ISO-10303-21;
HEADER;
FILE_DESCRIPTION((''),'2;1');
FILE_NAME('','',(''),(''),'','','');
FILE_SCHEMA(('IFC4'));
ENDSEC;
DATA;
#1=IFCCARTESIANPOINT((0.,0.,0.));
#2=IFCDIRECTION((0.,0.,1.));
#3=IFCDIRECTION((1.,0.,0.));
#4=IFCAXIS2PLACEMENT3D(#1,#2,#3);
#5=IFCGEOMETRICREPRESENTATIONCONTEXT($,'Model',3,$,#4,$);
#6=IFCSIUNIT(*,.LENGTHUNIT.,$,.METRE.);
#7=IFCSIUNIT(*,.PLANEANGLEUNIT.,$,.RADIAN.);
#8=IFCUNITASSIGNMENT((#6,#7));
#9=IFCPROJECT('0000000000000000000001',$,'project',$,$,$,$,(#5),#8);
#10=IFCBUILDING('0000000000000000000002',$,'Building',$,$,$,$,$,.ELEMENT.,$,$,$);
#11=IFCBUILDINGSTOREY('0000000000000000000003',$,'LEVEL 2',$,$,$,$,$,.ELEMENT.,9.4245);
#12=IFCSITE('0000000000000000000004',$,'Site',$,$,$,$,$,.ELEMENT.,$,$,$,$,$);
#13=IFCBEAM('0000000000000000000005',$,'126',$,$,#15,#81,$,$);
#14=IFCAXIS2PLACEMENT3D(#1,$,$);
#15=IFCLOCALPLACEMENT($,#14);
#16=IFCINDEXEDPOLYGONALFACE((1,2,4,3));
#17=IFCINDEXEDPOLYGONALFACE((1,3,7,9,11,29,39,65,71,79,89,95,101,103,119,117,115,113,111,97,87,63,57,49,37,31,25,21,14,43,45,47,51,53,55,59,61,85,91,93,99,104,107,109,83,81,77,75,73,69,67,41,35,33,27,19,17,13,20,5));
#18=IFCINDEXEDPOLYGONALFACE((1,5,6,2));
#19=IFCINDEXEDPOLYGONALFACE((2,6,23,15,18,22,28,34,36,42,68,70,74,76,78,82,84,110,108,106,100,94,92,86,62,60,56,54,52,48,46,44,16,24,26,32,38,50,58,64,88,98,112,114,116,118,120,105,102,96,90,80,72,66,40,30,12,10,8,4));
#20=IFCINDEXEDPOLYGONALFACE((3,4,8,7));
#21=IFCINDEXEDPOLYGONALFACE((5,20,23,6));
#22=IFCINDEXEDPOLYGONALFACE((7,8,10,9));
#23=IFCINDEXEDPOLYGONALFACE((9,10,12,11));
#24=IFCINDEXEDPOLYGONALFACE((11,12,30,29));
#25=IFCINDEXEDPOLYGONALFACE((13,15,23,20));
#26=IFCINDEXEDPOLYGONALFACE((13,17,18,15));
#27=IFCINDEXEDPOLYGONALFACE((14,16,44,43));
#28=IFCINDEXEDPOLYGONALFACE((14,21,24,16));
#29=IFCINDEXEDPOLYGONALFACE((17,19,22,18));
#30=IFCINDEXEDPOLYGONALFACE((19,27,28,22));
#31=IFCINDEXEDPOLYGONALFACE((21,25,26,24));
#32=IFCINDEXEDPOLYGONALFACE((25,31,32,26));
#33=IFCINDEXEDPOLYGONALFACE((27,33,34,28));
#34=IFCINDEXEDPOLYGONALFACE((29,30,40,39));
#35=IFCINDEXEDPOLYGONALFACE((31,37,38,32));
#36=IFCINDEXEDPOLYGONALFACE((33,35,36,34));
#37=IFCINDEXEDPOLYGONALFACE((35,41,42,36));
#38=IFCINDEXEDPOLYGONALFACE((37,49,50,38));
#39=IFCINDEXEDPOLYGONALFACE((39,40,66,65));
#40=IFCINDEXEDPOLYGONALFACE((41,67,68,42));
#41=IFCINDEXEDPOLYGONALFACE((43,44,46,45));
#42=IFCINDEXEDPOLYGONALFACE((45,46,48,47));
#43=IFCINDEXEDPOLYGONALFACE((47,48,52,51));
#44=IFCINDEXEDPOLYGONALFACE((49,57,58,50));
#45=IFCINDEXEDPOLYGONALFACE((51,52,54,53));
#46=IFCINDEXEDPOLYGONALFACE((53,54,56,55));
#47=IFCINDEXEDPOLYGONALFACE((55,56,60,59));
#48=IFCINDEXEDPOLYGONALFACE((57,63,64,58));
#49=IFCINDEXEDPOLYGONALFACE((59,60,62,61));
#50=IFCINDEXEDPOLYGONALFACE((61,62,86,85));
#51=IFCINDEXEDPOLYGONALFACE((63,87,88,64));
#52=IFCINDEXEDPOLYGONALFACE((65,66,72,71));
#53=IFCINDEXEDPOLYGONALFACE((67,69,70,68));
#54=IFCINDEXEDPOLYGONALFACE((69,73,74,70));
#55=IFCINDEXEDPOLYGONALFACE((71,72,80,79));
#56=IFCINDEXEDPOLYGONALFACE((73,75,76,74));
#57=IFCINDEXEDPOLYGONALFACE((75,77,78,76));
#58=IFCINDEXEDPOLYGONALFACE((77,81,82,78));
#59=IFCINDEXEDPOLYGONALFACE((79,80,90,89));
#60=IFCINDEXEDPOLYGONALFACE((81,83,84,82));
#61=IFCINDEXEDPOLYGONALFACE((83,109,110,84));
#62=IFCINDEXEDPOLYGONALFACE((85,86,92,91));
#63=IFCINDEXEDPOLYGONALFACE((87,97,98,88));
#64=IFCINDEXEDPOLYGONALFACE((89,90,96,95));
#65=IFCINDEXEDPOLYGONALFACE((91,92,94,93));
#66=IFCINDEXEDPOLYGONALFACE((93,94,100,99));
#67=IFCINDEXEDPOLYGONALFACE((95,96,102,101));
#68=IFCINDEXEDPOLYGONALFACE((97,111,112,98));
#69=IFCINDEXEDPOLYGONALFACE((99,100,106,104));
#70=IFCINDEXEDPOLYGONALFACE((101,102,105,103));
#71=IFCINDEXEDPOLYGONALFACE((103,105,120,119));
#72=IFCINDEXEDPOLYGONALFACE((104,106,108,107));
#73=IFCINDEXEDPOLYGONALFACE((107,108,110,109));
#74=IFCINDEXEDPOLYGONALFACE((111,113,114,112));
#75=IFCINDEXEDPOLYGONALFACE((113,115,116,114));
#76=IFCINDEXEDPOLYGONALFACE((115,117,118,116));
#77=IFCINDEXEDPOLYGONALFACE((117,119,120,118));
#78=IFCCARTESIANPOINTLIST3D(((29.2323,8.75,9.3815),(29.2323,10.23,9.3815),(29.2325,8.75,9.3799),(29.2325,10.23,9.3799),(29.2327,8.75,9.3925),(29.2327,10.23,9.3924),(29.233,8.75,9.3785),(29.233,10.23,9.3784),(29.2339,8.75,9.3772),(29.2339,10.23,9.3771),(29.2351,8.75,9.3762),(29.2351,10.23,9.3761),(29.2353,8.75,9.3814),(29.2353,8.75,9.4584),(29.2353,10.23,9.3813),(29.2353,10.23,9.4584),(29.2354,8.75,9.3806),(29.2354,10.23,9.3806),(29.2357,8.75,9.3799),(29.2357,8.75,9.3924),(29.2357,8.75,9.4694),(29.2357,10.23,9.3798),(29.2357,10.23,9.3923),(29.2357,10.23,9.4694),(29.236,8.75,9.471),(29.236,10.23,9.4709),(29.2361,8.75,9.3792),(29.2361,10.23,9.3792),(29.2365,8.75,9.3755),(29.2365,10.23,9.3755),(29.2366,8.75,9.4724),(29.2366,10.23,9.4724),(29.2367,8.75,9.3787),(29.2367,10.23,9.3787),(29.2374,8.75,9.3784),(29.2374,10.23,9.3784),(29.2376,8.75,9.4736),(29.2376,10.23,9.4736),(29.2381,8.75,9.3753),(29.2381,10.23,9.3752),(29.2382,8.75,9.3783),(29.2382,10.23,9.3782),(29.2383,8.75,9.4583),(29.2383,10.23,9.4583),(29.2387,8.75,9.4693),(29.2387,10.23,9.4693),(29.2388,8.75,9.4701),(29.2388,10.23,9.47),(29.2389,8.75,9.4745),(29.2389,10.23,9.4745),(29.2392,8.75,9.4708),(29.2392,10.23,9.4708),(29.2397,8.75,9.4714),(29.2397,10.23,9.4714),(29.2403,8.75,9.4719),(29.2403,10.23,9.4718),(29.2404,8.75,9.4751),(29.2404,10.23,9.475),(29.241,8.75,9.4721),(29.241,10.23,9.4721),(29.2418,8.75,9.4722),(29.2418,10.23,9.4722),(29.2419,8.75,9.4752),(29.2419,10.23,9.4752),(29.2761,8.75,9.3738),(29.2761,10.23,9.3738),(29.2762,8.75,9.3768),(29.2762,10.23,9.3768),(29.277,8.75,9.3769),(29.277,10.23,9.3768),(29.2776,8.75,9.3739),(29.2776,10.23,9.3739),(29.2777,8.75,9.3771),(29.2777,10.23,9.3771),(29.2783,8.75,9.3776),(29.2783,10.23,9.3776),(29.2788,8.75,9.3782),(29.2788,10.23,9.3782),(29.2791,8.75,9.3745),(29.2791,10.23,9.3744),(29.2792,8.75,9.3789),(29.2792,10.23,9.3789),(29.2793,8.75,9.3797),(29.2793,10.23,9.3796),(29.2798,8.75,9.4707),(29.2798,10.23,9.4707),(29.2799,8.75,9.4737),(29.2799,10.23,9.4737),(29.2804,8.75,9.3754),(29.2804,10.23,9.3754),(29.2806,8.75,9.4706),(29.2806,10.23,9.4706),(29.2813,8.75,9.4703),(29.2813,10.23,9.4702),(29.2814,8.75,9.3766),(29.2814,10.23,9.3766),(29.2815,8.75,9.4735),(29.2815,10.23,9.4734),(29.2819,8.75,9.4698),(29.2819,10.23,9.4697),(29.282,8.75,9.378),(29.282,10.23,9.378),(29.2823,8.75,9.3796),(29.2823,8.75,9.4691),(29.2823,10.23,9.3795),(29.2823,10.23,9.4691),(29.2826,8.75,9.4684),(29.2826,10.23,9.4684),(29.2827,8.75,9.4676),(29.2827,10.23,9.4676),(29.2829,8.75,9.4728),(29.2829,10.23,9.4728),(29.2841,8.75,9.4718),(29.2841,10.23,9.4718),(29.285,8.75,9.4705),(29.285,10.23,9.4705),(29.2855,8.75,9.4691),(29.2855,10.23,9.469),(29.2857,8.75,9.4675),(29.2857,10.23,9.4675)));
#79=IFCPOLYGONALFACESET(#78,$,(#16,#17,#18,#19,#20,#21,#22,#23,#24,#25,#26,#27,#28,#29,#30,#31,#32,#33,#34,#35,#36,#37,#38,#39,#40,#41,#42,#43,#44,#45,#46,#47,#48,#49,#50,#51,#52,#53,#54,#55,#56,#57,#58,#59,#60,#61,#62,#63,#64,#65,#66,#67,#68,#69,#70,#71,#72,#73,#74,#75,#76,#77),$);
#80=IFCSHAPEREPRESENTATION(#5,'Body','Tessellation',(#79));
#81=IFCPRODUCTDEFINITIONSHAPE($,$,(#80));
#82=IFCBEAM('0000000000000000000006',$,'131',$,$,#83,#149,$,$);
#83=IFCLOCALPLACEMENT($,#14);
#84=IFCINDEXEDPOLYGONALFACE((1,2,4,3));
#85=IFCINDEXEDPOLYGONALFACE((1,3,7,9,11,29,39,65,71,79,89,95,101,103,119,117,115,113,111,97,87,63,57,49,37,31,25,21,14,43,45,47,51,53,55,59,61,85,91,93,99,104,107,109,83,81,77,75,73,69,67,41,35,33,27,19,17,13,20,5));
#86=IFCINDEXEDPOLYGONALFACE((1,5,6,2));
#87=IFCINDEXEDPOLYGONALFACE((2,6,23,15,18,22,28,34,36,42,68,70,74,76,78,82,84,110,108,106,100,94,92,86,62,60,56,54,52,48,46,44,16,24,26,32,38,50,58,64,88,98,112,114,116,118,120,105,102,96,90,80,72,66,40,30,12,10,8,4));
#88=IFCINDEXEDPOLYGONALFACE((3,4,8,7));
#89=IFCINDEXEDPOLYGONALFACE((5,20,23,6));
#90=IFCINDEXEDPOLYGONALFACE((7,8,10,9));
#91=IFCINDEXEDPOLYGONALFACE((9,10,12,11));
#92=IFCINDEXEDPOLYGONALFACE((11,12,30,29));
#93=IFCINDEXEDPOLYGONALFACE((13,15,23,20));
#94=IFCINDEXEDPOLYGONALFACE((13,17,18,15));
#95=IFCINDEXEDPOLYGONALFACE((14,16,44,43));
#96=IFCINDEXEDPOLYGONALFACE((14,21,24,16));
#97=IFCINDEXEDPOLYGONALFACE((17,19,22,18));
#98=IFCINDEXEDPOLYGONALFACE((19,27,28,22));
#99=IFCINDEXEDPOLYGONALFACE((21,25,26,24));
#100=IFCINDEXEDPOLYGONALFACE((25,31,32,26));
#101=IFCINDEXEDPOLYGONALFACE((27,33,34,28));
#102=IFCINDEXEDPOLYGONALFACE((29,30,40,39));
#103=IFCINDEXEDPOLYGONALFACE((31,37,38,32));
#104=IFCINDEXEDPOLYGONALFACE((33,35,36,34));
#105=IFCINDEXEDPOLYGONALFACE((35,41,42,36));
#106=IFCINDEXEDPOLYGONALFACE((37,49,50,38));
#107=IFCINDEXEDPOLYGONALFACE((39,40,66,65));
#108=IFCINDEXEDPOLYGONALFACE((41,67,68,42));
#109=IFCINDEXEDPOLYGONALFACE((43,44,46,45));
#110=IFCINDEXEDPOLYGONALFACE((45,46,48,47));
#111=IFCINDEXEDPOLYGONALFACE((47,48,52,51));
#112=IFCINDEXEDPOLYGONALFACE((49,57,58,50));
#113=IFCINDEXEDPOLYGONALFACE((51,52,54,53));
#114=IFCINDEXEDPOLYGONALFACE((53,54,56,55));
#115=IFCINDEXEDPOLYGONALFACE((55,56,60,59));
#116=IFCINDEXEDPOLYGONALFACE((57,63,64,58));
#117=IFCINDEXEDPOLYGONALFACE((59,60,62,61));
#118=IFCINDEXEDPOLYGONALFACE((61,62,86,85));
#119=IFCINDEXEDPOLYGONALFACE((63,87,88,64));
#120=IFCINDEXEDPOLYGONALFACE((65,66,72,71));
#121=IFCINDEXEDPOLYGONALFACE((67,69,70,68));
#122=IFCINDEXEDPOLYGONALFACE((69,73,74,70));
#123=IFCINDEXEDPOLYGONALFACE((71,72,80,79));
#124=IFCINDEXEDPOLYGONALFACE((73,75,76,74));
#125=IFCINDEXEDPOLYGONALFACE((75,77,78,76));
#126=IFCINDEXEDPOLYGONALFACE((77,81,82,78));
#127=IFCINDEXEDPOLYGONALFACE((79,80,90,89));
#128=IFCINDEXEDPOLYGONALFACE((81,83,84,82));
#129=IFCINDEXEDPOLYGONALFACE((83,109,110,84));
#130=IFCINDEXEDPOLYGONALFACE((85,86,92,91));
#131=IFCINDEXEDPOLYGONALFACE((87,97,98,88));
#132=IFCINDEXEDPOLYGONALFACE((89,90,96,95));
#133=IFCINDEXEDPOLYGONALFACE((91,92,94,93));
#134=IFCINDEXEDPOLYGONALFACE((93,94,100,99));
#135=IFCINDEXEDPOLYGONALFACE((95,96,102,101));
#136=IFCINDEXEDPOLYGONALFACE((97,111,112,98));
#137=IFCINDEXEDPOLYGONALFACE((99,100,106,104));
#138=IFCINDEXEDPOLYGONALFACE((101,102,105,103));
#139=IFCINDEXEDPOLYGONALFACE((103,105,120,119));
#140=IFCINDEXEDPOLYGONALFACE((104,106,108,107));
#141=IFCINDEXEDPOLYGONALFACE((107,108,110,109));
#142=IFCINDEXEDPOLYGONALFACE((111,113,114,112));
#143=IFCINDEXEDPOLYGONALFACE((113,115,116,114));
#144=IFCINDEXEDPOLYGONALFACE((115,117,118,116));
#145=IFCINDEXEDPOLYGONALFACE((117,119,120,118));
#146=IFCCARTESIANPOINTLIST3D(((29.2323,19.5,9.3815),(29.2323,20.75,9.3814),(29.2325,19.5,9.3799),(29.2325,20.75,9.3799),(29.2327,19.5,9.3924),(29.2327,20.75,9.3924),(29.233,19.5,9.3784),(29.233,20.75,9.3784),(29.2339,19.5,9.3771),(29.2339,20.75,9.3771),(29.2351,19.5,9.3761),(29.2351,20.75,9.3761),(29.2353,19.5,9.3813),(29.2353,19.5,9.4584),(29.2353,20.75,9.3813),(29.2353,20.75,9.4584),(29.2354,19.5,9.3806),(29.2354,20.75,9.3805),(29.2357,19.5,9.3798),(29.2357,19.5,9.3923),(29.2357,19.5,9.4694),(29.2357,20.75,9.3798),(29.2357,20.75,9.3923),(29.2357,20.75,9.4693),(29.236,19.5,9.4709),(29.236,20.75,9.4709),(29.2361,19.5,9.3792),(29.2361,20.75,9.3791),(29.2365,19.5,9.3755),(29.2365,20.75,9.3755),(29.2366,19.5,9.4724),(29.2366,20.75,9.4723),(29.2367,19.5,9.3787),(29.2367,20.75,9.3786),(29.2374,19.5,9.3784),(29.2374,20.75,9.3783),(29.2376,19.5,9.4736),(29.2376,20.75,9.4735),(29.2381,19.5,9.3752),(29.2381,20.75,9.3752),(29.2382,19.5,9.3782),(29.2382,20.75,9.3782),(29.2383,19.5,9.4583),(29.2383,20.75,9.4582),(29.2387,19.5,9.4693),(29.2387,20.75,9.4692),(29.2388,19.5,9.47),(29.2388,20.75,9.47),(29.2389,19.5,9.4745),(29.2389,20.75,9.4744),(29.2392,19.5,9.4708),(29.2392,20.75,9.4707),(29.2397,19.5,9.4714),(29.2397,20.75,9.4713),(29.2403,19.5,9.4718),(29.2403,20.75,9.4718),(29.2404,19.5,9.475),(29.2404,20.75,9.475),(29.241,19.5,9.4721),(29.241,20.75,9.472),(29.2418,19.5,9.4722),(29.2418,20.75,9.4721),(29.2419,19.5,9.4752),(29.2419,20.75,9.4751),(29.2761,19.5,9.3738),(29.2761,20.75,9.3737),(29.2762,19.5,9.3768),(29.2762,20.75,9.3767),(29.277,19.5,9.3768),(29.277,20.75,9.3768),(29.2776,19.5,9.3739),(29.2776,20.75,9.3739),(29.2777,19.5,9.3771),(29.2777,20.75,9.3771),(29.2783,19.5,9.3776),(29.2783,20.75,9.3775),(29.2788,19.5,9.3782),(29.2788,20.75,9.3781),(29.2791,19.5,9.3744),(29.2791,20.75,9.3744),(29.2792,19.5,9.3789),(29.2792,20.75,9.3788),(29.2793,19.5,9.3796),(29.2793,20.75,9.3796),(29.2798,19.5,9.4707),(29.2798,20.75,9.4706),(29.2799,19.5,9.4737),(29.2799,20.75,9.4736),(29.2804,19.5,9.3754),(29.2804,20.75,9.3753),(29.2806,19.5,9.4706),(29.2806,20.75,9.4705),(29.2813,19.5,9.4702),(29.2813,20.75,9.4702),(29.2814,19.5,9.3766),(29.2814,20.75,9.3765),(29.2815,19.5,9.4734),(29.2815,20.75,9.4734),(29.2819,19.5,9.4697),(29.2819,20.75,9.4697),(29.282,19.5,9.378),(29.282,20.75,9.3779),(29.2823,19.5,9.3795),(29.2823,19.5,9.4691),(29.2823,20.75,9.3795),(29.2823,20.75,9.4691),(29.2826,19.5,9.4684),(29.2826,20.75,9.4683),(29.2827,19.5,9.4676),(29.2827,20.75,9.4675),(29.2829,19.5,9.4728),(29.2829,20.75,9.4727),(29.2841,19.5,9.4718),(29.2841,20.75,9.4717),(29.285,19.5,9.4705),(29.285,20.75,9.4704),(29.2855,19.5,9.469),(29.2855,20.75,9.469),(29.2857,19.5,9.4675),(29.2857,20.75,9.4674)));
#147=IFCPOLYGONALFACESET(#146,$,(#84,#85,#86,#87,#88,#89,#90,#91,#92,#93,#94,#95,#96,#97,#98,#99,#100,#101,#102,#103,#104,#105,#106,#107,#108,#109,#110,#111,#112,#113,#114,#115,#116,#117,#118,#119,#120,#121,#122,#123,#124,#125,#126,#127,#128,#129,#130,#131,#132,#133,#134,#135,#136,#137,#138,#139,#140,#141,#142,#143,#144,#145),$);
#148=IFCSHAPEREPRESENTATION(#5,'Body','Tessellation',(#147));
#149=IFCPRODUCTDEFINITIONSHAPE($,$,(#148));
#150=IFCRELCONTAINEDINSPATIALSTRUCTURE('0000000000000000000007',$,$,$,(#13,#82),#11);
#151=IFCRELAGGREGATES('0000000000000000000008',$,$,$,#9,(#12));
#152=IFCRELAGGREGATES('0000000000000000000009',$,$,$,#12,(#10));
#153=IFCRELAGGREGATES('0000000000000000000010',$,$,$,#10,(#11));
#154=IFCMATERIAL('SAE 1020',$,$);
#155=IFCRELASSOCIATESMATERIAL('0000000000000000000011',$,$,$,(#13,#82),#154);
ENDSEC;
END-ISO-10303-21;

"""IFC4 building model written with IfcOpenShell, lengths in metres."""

from ifc_helpers import new_model, si_unit, frame, origin_with_axes, origin_2d_with_axis, place, context, project, spatial, c_section, extrude, material, material_profile, profile_set, profile_usage, element, save


model = new_model("IFC4")

# Units and contexts
model_context = context("Model", 3, world=origin_with_axes())
ifc_project = project(units=[si_unit("LENGTHUNIT", "METRE"), si_unit("PLANEANGLEUNIT", "RADIAN")], contexts=[model_context])

# Site, building, storey
site = spatial("IfcSite", under=ifc_project, Name="Site", CompositionType="ELEMENT")
building = spatial("IfcBuilding", under=site, Name="Building", CompositionType="ELEMENT")
storey = spatial("IfcBuildingStorey", under=building, Name="LEVEL 2", CompositionType="ELEMENT", Elevation=9.4245)

# Beams
ifc_material = material(Name="SAE 1020")
ifc_material_profile_1 = material_profile(ifc_material, c_section(Depth=0.1, Width=0.05, WallThickness=0.003, Girth=0.017, InternalFilletRadius=0.003, at=origin_2d_with_axis()))
ifc_profile_set_1 = profile_set([ifc_material_profile_1])
ifc_profile_usage_1 = profile_usage(ifc_profile_set_1, cardinal=10)
beam_1_placement = place(None, frame((29.259, 8.75, 9.4245), z_axis=(0.0, 1.0, -0.00003), x_axis=(-0.999256, 0.000001, 0.038562)))
element("IfcBeam", 1, at=beam_1_placement, inside=storey, material=ifc_profile_usage_1, Name="126", context=model_context, shape_type="SweptSolid", body=[
    extrude(c_section(Depth=0.1, Width=0.05, WallThickness=0.003, Girth=0.017, InternalFilletRadius=0.003, at=origin_2d_with_axis()), origin_with_axes(), (0.0, 0.0, 1.0), 1.48),
])
ifc_material_profile_2 = material_profile(ifc_material, c_section(Depth=0.1, Width=0.05, WallThickness=0.003, Girth=0.017, InternalFilletRadius=0.003, at=origin_2d_with_axis()))
ifc_profile_set_2 = profile_set([ifc_material_profile_2])
ifc_profile_usage_2 = profile_usage(ifc_profile_set_2, cardinal=10)
beam_2_placement = place(None, frame((29.259, 19.5, 9.4245), z_axis=(0.0, 1.0, -0.00003), x_axis=(-0.999256, 0.000001, 0.038562)))
element("IfcBeam", 2, at=beam_2_placement, inside=storey, material=ifc_profile_usage_2, Name="131", context=model_context, shape_type="SweptSolid", body=[
    extrude(c_section(Depth=0.1, Width=0.05, WallThickness=0.003, Girth=0.017, InternalFilletRadius=0.003, at=origin_2d_with_axis()), origin_with_axes(), (0.0, 0.0, 1.0), 1.25),
])

save(model, "model.ifc")
